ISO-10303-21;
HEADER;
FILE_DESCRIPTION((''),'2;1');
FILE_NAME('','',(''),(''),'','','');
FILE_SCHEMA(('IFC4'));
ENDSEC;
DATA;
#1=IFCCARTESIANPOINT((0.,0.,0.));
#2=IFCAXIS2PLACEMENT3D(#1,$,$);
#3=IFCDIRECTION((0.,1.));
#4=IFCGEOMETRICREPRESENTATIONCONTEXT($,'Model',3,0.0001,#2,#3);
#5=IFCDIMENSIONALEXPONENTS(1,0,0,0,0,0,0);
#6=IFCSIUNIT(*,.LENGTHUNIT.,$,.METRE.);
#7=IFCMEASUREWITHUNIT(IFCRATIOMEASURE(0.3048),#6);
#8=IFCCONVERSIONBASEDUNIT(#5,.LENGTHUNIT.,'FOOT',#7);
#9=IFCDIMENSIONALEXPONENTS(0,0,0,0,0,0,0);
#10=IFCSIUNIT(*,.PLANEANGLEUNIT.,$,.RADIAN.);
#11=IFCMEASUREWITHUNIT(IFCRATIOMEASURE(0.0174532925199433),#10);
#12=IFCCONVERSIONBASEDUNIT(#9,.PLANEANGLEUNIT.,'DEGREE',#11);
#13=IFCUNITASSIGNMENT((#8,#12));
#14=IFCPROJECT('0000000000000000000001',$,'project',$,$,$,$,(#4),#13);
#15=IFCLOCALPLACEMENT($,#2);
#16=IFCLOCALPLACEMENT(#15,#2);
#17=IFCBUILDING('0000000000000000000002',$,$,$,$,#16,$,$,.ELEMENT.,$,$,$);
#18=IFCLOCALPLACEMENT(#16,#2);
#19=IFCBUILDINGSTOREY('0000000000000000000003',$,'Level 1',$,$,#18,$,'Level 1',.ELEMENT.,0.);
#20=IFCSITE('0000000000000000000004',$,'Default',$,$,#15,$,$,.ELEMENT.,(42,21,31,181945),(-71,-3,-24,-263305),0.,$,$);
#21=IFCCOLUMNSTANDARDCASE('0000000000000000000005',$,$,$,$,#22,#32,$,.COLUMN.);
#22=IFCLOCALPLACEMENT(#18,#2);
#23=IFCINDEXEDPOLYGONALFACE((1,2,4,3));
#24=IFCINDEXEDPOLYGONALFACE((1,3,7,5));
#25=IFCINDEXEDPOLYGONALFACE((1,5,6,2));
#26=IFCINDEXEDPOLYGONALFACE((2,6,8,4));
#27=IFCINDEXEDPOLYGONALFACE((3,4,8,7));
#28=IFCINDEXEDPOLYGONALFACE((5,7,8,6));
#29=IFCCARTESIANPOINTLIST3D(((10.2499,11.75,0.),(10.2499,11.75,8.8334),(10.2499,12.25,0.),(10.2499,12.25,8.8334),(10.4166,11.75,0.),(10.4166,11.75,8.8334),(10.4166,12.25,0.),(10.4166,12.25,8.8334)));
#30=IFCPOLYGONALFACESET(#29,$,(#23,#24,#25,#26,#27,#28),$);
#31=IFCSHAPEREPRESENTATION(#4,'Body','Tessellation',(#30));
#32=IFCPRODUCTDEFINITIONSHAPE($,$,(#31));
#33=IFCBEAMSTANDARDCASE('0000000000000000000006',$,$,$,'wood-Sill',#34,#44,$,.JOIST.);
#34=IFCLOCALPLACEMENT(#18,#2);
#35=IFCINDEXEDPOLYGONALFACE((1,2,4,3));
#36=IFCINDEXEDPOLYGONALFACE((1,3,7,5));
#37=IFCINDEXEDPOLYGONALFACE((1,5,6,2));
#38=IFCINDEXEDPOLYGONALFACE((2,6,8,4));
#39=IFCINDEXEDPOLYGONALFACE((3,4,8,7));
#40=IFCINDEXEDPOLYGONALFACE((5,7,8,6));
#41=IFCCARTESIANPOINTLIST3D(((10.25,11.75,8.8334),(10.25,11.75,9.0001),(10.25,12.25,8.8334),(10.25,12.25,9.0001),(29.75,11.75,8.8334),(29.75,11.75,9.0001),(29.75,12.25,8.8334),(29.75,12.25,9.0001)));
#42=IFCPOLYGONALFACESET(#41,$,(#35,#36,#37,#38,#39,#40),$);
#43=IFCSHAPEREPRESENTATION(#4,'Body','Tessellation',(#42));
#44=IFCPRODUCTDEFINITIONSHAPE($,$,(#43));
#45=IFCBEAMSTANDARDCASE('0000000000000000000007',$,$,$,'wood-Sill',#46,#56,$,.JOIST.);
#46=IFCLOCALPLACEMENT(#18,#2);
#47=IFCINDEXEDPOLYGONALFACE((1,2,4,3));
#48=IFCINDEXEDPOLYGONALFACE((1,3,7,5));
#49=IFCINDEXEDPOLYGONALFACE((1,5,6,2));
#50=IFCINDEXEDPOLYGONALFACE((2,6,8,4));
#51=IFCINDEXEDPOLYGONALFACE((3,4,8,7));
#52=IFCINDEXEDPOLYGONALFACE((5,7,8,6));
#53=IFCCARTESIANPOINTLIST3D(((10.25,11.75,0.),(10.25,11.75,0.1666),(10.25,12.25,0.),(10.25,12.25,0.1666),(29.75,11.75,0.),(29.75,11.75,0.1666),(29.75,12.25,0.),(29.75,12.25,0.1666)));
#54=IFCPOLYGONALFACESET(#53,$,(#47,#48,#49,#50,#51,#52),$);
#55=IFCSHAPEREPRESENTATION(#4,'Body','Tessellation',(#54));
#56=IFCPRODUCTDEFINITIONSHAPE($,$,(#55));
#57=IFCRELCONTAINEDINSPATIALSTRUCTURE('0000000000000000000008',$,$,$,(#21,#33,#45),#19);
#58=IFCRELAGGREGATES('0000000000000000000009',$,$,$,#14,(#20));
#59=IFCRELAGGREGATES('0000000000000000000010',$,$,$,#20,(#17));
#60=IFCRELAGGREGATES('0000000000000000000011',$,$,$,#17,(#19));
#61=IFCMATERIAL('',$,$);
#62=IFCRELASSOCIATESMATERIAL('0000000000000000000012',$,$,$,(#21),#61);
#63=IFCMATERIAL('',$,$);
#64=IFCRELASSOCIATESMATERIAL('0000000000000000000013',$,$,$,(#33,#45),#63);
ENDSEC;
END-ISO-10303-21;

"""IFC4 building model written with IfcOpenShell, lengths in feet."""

from ifc_helpers import new_model, entity, si_unit, converted_unit, direction, frame, origin, origin_with_axes, place, context, project, spatial, rectangle, extrude, material, element, save


model = new_model("IFC4")

# Units and contexts
model_context = context("Model", 3, precision=0.0001, world=origin(), true_north=direction((0.0, 1.0)))
ifc_project = project(units=[converted_unit("LENGTHUNIT", "FOOT", entity("IfcRatioMeasure", 0.3048), si_unit("LENGTHUNIT", "METRE"), dimensions=[1, 0, 0, 0, 0, 0, 0]), converted_unit("PLANEANGLEUNIT", "DEGREE", entity("IfcRatioMeasure", 0.0174532925199433), si_unit("PLANEANGLEUNIT", "RADIAN"), dimensions=[0, 0, 0, 0, 0, 0, 0])], contexts=[model_context])

# Site, building, storey
site_placement = place(None, origin())
site = spatial("IfcSite", under=ifc_project, at=site_placement, Name="Default", CompositionType="ELEMENT", RefLatitude=(42, 21, 31, 181945), RefLongitude=(-71, -3, -24, -263305), RefElevation=0.0)
building_placement = place(site_placement, origin())
building = spatial("IfcBuilding", under=site, at=building_placement, CompositionType="ELEMENT")
storey_placement = place(building_placement, origin())
storey = spatial("IfcBuildingStorey", under=building, at=storey_placement, Name="Level 1", LongName="Level 1", CompositionType="ELEMENT", Elevation=0.0)

# Column
ifc_material_1 = material(Name="")
placement_1 = place(storey_placement, frame((10.25, 12.0, 0.0)))
for number, where, z_axis, x_axis in (
    (1, (0.0833, 0.0, 0.0), (0.0, 0.0, 1.0), (1.0, 0.0, 0.0)),
):
    element("IfcColumnStandardCase", number, at=place(placement_1, frame(where, z_axis=z_axis, x_axis=x_axis)), inside=storey, material=ifc_material_1, PredefinedType="COLUMN", context=model_context, shape_type="SweptSolid", body=[
        extrude(rectangle(XDim=0.1667, YDim=0.5), origin(), (0.0, 0.0, 1.0), 8.8334),
    ])

# Beams
ifc_material_2 = material(Name="")
for number, where, z_axis, x_axis in (
    (2, (0.0, 0.0, 8.9167), (1.0, 0.0, 0.0), (0.0, 0.0, 1.0)),
    (3, (0.0, 0.0, 0.0833), (1.0, 0.0, 0.0), (0.0, 0.0, 1.0)),
):
    element("IfcBeamStandardCase", number, at=place(placement_1, frame(where, z_axis=z_axis, x_axis=x_axis)), inside=storey, material=ifc_material_2, ObjectType="wood-Sill", PredefinedType="JOIST", context=model_context, shape_type="SweptSolid", body=[
        extrude(rectangle(XDim=0.1667, YDim=0.5), origin_with_axes(), (0.0, 0.0, 1.0), 19.5),
    ])

save(model, "model.ifc")
